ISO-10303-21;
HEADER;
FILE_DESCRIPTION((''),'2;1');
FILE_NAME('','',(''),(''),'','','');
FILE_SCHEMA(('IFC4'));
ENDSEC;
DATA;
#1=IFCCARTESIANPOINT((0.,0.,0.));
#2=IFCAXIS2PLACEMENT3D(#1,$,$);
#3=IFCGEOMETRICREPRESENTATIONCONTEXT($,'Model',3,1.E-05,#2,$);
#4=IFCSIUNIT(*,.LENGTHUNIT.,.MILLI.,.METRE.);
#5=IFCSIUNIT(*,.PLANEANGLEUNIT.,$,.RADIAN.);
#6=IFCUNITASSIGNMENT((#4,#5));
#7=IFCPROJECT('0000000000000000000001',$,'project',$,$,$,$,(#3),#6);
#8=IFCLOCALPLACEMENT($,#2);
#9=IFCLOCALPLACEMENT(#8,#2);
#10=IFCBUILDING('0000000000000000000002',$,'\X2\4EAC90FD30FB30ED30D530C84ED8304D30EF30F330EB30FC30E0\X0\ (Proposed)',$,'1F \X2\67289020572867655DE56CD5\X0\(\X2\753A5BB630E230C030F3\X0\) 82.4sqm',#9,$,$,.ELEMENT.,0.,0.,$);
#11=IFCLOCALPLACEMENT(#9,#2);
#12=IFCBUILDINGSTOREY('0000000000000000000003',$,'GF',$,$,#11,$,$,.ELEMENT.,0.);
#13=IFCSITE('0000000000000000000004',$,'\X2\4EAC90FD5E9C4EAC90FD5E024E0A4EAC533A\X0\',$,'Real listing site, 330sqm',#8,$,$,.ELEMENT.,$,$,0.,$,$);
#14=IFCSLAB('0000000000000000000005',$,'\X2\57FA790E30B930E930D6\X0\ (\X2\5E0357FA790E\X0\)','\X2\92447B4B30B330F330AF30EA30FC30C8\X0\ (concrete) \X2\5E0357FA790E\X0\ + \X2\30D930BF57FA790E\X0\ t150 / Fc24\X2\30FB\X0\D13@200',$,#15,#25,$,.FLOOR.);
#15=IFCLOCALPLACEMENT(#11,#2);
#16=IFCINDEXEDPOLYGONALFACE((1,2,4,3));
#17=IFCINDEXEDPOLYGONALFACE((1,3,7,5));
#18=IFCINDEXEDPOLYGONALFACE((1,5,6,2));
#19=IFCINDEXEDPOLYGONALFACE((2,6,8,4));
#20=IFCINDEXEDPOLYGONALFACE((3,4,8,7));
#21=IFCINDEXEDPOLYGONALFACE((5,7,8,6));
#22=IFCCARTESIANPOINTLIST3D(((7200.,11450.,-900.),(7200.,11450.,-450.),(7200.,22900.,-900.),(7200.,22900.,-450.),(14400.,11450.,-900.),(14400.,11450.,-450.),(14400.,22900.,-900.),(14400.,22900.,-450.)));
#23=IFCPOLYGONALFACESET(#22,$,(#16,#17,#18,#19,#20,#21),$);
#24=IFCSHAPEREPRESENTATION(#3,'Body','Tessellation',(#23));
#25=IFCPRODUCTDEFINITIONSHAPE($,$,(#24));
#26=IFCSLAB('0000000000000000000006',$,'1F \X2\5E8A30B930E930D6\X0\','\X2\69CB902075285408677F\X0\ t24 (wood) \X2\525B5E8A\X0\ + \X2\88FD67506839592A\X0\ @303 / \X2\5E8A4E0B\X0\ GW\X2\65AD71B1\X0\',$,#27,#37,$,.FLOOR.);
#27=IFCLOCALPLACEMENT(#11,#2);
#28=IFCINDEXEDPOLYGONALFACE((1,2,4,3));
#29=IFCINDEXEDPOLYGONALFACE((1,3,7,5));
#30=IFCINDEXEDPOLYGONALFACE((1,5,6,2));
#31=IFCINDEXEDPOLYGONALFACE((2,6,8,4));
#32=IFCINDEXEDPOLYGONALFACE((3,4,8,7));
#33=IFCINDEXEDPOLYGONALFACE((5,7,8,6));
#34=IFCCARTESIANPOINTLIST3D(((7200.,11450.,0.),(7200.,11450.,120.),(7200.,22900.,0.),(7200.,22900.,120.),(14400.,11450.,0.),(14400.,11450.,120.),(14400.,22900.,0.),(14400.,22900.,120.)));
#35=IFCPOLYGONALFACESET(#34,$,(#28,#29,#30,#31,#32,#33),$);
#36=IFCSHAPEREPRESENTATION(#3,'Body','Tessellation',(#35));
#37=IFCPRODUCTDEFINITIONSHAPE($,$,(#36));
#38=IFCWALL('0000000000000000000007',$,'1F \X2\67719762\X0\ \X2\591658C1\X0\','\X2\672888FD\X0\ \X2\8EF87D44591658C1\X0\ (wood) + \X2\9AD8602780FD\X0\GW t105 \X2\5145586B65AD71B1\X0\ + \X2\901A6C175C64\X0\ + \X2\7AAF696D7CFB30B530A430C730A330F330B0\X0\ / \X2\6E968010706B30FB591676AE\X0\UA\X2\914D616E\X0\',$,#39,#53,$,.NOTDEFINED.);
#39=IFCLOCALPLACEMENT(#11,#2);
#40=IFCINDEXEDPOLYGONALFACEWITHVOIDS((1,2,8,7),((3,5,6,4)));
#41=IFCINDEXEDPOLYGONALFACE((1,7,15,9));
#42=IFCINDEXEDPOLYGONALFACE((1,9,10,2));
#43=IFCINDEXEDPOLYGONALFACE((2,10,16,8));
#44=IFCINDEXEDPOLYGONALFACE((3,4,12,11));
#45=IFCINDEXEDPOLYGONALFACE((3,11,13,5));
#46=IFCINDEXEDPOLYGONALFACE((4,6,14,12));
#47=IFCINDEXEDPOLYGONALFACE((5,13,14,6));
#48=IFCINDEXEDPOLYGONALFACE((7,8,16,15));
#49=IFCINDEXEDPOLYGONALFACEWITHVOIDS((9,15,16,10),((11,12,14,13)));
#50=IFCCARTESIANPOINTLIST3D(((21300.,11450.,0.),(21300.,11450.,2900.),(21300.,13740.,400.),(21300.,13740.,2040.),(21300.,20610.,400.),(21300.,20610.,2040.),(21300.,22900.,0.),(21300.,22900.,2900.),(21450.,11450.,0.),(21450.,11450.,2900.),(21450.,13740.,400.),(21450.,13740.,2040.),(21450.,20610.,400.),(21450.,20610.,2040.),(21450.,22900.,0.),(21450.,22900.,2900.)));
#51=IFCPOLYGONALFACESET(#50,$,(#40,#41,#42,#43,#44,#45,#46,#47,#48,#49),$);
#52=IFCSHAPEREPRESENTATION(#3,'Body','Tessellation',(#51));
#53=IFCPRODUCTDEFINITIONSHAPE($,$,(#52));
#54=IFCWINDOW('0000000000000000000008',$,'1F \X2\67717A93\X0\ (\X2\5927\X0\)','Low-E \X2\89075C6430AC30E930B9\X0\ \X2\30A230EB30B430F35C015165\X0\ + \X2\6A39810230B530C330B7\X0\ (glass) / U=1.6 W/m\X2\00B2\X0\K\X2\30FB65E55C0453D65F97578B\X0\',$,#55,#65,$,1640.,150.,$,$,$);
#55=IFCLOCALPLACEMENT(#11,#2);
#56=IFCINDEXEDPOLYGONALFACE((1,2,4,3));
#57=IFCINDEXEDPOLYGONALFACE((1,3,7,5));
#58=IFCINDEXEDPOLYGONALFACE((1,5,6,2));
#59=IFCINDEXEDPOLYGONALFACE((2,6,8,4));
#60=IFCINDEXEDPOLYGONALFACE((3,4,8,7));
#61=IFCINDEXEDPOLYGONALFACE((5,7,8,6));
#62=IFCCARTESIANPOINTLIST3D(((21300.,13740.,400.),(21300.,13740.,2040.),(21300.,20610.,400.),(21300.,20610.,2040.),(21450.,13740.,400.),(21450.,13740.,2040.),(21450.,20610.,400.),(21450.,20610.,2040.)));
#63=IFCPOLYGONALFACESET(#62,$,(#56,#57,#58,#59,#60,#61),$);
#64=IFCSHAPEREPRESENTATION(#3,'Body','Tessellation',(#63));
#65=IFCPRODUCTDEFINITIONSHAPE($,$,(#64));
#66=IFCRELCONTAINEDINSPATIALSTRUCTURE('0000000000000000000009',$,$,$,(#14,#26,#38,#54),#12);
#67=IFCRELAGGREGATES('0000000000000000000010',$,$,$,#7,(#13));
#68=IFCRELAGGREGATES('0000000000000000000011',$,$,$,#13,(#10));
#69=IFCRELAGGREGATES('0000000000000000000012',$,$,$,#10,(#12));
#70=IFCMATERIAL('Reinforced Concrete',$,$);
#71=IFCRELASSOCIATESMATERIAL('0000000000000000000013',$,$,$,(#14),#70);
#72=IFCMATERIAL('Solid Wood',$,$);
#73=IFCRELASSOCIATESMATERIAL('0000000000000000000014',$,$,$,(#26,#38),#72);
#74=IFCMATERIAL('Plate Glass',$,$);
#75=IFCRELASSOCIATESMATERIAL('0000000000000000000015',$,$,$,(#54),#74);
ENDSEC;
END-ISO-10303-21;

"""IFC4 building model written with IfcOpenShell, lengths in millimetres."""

from ifc_helpers import new_model, si_unit, frame, frame_2d, origin, place, context, project, spatial, rectangle, extrude, material, element, fill, save


model = new_model("IFC4")

# Units and contexts
model_context = context("Model", 3, precision=1e-05, world=origin())
ifc_project = project(units=[si_unit("LENGTHUNIT", "METRE", prefix="MILLI"), si_unit("PLANEANGLEUNIT", "RADIAN")], contexts=[model_context])

# Site, building, storey
site_placement = place(None, origin())
site = spatial("IfcSite", under=ifc_project, at=site_placement, Name="京都府京都市上京区", ObjectType="Real listing site, 330sqm", CompositionType="ELEMENT", RefElevation=0.0)
building_placement = place(site_placement, origin())
building = spatial("IfcBuilding", under=site, at=building_placement, Name="京都・ロフト付きワンルーム (Proposed)", ObjectType="1F 木造在来工法(町家モダン) 82.4sqm", CompositionType="ELEMENT", ElevationOfRefHeight=0.0, ElevationOfTerrain=0.0)
storey_placement = place(building_placement, origin())
storey = spatial("IfcBuildingStorey", under=building, at=storey_placement, Name="GF", CompositionType="ELEMENT", Elevation=0.0)

# Shared definitions
ifc_material_1 = material(Name="Solid Wood")

# Slabs
ifc_material_2 = material(Name="Reinforced Concrete")
slab_1_placement = place(storey_placement, frame((3600.0, 5725.0, -450.0)))
element("IfcSlab", 1, at=slab_1_placement, inside=storey, material=ifc_material_2, Name="基礎スラブ (布基礎)", Description="鉄筋コンクリート (concrete) 布基礎 + ベタ基礎 t150 / Fc24・D13@200", PredefinedType="FLOOR", context=model_context, shape_type="SweptSolid", body=[
    extrude(rectangle(XDim=7200.0, YDim=11450.0, at=frame_2d((3600.0, 5725.0))), frame((3600.0, 5725.0, -450.0)), (0.0, 0.0, 1.0), 450.0),
])
slab_2_placement = place(storey_placement, frame((3600.0, 5725.0, 0.0)))
element("IfcSlab", 2, at=slab_2_placement, inside=storey, material=ifc_material_1, Name="1F 床スラブ", Description="構造用合板 t24 (wood) 剛床 + 製材根太 @303 / 床下 GW断熱", PredefinedType="FLOOR", context=model_context, shape_type="SweptSolid", body=[
    extrude(rectangle(XDim=7200.0, YDim=11450.0, at=frame_2d((3600.0, 5725.0))), frame((3600.0, 5725.0, 0.0)), (0.0, 0.0, 1.0), 120.0),
])

# Shared definitions
ifc_material_3 = material(Name="Plate Glass")

# Wall, opening, window
wall_1_placement = place(storey_placement, frame((10650.0, 5725.0, 0.0)))
wall_1 = element("IfcWall", 3, at=wall_1_placement, inside=storey, material=ifc_material_1, Name="1F 東面 外壁", Description="木製 軸組外壁 (wood) + 高性能GW t105 充填断熱 + 通気層 + 窯業系サイディング / 準耐火・外皮UA配慮", PredefinedType="NOTDEFINED", context=model_context, shape_type="SweptSolid", body=[
    extrude(rectangle(XDim=150.0, YDim=11450.0, at=frame_2d((75.0, 5725.0))), frame((10650.0, 5725.0, 0.0)), (0.0, 0.0, 1.0), 2900.0),
])
opening_1_placement = place(storey_placement, frame((10650.0, 6870.0, 200.0)))
opening_1 = element("IfcOpeningElement", 4, at=opening_1_placement, cuts=wall_1, PredefinedType="NOTDEFINED", context=model_context, shape_type="SweptSolid", body=[
    extrude(rectangle(XDim=150.0, YDim=6870.0, at=frame_2d((75.0, 3435.0))), frame((10650.0, 6870.0, 200.0)), (0.0, 0.0, 1.0), 1640.0),
])
window_1_placement = place(storey_placement, frame((10650.0, 6870.0, 200.0)))
window_1 = element("IfcWindow", 5, at=window_1_placement, inside=storey, material=ifc_material_3, Name="1F 東窓 (大)", Description="Low-E 複層ガラス アルゴン封入 + 樹脂サッシ (glass) / U=1.6 W/m²K・日射取得型", OverallHeight=1640.0, OverallWidth=150.0, context=model_context, shape_type="SweptSolid", body=[
    extrude(rectangle(XDim=150.0, YDim=6870.0, at=frame_2d((75.0, 3435.0))), frame((10650.0, 6870.0, 200.0)), (0.0, 0.0, 1.0), 1640.0),
])
fill(opening_1, window_1)

save(model, "model.ifc")
